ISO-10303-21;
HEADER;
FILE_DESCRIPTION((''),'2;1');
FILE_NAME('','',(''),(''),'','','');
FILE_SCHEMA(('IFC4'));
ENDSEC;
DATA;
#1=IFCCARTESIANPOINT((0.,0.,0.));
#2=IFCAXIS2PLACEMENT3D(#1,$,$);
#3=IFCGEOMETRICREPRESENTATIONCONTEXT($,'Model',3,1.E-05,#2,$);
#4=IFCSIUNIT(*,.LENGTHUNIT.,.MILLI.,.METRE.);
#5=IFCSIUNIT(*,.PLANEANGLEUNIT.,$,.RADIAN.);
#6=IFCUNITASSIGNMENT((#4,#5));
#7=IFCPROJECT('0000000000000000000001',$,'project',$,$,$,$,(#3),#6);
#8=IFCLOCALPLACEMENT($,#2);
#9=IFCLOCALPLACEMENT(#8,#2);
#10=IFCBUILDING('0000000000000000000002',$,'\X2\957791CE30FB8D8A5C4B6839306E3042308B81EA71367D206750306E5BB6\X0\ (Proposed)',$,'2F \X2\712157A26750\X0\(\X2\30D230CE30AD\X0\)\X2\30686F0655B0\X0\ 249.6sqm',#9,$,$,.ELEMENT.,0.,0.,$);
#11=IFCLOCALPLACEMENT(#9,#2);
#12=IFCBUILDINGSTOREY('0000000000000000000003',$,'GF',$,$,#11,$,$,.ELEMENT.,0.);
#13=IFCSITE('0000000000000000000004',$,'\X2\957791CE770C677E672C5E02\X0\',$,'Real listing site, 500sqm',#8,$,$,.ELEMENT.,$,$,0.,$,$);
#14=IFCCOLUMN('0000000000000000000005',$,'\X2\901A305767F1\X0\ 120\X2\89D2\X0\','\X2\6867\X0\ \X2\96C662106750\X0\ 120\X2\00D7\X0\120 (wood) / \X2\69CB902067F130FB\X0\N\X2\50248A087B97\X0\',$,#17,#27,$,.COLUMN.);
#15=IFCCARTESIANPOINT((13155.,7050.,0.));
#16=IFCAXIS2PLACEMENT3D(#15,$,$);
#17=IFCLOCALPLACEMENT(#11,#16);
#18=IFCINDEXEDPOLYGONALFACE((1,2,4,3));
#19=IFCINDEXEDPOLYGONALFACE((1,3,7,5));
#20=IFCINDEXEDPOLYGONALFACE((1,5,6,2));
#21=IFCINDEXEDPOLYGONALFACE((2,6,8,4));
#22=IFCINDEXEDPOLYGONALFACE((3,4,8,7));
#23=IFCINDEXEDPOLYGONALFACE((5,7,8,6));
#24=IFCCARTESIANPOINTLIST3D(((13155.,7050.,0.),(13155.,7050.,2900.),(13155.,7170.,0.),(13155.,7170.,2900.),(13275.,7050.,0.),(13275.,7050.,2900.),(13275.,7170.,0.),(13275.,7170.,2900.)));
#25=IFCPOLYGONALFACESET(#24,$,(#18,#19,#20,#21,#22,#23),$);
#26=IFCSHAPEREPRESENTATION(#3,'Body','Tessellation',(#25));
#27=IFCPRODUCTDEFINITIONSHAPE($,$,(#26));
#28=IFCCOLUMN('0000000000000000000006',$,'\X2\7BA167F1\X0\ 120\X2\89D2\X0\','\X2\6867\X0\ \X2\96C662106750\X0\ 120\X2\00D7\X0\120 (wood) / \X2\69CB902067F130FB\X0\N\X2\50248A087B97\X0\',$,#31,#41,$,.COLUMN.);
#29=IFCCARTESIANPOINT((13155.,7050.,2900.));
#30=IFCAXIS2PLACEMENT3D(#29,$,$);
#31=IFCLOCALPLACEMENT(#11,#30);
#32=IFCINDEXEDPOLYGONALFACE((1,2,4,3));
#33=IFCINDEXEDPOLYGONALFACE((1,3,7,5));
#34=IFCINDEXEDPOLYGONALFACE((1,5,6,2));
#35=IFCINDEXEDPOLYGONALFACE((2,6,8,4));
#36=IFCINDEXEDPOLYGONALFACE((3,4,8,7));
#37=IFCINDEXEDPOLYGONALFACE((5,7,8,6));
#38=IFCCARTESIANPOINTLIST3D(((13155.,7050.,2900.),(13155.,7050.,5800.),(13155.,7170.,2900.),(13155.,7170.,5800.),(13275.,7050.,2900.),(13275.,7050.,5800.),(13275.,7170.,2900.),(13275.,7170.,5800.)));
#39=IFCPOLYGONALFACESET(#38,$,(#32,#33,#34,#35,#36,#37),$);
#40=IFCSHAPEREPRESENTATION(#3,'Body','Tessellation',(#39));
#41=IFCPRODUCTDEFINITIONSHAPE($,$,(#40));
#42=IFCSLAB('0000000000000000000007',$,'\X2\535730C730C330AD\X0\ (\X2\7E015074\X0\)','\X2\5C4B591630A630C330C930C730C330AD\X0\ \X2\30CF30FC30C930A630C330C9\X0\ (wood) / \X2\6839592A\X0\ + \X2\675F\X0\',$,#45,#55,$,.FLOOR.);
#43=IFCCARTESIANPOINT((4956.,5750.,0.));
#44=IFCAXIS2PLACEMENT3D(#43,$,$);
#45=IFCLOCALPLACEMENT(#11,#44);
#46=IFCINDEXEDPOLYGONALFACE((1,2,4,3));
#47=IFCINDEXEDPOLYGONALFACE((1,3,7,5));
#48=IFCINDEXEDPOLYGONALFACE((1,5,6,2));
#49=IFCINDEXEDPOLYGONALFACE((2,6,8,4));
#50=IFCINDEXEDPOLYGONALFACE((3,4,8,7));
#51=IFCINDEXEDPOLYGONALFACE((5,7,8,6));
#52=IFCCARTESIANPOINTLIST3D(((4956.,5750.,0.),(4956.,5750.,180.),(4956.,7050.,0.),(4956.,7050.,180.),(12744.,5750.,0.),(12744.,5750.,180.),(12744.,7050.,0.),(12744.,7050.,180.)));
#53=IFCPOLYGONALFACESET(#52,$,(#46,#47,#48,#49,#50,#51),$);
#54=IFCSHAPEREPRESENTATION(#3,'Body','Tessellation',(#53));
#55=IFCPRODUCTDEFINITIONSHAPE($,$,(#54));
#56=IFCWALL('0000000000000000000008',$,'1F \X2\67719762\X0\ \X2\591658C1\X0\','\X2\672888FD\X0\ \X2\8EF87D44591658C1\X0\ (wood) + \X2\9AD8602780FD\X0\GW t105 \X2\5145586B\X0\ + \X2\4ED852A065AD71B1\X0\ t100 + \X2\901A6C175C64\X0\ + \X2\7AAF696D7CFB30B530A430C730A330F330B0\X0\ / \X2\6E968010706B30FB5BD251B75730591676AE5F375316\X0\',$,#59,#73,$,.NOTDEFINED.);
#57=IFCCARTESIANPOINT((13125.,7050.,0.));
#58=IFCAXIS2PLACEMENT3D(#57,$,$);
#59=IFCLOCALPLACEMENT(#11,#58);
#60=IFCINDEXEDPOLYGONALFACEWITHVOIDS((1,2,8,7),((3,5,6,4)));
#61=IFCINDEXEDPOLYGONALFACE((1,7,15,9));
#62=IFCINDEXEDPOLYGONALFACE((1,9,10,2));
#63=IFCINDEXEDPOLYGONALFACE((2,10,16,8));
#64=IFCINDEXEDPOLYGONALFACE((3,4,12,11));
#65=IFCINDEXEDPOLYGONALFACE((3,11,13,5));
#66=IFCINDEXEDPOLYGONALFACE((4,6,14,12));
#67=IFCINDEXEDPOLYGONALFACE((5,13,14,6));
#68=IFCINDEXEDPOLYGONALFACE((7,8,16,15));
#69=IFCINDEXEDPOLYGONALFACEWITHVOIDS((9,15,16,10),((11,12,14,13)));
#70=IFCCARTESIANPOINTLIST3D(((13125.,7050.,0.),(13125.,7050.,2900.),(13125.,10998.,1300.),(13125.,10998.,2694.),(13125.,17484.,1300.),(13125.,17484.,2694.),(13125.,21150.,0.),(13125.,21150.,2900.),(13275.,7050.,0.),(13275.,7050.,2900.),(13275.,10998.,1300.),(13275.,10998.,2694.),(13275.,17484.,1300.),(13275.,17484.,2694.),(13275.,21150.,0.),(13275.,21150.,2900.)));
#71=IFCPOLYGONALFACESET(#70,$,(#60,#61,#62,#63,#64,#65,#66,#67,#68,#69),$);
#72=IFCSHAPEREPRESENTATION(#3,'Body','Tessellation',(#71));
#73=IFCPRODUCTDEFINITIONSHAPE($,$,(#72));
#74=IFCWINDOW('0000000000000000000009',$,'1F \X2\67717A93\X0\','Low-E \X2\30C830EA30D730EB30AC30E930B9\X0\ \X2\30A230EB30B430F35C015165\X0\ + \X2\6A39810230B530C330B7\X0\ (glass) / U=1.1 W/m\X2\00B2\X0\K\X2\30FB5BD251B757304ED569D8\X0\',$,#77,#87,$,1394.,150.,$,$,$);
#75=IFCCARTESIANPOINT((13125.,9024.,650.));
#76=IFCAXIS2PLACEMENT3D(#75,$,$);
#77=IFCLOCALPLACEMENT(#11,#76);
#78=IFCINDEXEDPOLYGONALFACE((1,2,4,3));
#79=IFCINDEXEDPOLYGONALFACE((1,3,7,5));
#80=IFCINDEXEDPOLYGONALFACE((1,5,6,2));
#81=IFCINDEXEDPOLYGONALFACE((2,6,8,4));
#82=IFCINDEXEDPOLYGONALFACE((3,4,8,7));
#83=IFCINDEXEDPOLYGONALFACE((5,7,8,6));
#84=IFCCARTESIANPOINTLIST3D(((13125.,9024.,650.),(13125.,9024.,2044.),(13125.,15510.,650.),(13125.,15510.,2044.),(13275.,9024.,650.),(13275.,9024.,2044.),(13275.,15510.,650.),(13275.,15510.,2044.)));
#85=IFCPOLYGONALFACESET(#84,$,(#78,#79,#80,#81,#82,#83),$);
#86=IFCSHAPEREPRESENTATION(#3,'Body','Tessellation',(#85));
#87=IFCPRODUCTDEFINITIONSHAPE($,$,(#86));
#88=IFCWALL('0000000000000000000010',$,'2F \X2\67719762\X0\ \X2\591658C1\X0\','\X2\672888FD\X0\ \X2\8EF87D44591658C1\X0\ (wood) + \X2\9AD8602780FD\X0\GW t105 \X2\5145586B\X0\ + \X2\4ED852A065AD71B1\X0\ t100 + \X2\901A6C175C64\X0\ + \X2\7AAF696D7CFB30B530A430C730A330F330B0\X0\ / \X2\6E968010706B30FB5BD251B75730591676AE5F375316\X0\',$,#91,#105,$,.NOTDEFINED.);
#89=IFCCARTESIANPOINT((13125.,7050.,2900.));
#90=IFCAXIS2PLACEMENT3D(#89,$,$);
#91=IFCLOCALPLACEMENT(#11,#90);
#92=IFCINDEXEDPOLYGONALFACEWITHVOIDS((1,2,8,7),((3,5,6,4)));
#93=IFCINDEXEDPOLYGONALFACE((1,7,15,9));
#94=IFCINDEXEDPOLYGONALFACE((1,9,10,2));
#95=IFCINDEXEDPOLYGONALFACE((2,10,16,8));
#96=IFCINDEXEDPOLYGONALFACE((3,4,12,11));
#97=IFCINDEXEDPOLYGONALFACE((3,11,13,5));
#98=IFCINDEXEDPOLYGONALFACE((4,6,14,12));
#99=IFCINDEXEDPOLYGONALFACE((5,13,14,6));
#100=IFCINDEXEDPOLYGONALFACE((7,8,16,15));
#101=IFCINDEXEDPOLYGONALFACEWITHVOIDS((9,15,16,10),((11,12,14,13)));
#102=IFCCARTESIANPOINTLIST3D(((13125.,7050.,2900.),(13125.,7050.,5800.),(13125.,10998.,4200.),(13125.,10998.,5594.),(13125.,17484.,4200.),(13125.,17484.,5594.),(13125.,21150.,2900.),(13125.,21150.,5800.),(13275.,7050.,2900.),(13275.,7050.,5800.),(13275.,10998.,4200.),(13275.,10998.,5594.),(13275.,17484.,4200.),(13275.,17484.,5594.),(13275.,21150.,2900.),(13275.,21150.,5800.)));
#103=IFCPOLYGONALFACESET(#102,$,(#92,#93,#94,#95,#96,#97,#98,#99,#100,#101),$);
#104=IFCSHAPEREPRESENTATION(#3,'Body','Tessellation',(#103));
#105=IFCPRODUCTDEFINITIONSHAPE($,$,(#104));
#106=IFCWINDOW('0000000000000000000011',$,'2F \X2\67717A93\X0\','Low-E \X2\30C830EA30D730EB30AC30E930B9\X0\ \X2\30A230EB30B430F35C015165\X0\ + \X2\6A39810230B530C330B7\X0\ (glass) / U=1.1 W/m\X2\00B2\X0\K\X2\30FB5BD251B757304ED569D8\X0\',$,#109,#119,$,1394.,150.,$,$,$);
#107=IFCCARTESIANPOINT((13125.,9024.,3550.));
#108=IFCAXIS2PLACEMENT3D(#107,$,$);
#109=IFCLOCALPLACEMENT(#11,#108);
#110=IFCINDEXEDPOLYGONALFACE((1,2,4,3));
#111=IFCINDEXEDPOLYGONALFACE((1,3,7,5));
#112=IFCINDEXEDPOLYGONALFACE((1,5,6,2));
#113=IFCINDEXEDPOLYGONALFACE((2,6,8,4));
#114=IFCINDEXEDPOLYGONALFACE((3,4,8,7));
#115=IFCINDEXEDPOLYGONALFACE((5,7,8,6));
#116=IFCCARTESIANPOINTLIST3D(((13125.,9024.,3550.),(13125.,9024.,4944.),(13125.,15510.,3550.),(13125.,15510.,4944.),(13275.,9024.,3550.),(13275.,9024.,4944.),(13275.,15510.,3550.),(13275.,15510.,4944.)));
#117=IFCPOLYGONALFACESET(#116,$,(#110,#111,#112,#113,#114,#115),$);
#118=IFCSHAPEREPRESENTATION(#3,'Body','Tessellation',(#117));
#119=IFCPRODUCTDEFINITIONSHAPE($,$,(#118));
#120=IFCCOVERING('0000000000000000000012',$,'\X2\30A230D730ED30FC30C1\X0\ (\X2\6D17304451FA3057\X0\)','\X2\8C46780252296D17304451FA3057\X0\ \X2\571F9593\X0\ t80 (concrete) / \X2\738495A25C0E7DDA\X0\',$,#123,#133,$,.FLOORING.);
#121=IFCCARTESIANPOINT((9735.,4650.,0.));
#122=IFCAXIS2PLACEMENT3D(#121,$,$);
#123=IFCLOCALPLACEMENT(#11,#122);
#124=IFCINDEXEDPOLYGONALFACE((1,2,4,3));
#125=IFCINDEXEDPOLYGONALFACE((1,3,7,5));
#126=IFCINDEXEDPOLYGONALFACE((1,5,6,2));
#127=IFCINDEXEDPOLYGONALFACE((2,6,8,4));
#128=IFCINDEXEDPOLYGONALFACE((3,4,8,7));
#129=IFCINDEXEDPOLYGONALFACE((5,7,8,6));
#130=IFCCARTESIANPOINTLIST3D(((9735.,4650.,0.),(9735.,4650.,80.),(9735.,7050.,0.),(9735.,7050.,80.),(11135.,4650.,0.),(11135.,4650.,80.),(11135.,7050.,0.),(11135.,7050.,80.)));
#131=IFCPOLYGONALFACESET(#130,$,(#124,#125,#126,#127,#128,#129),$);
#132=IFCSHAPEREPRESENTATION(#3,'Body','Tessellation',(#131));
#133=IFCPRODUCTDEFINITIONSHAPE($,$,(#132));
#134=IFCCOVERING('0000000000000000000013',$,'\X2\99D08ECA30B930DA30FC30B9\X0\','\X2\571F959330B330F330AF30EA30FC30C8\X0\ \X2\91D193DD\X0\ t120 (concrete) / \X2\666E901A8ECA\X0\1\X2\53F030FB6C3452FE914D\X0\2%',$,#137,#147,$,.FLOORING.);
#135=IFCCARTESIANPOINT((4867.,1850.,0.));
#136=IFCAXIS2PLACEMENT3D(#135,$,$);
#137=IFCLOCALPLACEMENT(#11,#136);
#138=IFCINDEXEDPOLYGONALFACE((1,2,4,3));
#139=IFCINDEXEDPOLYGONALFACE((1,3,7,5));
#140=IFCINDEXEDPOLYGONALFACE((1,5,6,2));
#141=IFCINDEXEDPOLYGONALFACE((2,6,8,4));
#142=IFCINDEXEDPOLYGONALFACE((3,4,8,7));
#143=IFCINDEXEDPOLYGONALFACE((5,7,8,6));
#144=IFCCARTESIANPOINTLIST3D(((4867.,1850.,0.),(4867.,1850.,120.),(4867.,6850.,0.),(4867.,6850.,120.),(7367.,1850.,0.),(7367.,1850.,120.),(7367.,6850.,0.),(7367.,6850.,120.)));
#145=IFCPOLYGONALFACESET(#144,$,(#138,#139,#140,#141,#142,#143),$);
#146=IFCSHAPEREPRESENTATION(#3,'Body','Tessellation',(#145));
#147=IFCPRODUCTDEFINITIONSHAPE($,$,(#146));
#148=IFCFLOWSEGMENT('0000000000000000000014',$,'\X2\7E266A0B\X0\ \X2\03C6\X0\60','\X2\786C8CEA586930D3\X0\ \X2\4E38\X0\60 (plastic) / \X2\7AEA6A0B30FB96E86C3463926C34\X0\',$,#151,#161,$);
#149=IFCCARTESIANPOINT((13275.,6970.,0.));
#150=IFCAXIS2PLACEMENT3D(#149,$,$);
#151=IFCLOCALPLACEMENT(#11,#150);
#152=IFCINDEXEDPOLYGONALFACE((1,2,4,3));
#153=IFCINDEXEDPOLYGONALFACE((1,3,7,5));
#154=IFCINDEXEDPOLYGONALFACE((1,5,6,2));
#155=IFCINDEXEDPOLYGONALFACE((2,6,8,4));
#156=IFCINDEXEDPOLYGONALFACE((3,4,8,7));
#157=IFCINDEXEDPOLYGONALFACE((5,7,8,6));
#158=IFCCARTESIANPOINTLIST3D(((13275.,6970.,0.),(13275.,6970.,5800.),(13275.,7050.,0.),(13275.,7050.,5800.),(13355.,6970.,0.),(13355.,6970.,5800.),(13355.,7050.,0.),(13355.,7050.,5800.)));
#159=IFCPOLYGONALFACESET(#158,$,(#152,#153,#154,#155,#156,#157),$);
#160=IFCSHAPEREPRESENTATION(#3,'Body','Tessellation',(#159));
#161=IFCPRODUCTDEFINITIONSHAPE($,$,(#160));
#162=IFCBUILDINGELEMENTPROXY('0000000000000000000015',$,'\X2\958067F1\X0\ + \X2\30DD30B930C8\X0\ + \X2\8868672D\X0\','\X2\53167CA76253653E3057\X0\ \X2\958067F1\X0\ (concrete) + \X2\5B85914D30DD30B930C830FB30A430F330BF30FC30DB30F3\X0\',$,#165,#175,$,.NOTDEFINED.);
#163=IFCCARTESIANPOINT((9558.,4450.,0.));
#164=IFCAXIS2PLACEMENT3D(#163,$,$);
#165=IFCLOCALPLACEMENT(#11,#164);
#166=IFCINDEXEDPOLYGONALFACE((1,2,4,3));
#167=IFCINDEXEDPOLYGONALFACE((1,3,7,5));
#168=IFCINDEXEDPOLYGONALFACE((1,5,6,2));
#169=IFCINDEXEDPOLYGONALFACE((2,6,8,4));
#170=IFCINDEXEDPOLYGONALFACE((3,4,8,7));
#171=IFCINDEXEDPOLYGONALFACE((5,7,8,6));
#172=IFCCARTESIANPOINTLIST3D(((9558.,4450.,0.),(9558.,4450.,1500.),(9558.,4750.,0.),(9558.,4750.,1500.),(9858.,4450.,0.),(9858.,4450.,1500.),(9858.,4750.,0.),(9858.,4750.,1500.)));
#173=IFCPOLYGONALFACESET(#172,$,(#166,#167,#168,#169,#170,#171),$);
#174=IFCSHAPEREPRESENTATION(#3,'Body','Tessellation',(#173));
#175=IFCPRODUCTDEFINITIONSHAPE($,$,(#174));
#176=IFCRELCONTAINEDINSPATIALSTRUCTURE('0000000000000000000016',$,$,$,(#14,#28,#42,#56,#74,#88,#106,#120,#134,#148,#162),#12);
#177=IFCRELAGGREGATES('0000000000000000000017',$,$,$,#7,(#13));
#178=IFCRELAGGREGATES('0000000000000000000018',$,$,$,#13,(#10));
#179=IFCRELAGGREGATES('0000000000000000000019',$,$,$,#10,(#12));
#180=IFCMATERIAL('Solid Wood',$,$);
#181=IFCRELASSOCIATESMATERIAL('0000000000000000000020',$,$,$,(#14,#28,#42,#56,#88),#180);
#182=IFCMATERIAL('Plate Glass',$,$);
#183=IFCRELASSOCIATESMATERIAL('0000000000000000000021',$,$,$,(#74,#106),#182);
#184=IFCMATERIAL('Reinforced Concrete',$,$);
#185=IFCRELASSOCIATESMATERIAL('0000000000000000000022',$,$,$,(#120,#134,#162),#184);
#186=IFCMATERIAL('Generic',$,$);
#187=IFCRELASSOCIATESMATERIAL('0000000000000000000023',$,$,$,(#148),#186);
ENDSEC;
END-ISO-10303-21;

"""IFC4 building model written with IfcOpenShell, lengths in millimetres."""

from ifc_helpers import new_model, si_unit, frame, frame_2d, origin, place, context, project, spatial, rectangle, extrude, material, element, fill, save


model = new_model("IFC4")

# Units and contexts
model_context = context("Model", 3, precision=1e-05, world=origin())
ifc_project = project(units=[si_unit("LENGTHUNIT", "METRE", prefix="MILLI"), si_unit("PLANEANGLEUNIT", "RADIAN")], contexts=[model_context])

# Site, building, storey
site_placement = place(None, origin())
site = spatial("IfcSite", under=ifc_project, at=site_placement, Name="長野県松本市", ObjectType="Real listing site, 500sqm", CompositionType="ELEMENT", RefElevation=0.0)
building_placement = place(site_placement, origin())
building = spatial("IfcBuilding", under=site, at=building_placement, Name="長野・越屋根のある自然素材の家 (Proposed)", ObjectType="2F 無垢材(ヒノキ)と漆喰 249.6sqm", CompositionType="ELEMENT", ElevationOfRefHeight=0.0, ElevationOfTerrain=0.0)
storey_placement = place(building_placement, origin())
storey = spatial("IfcBuildingStorey", under=building, at=storey_placement, Name="GF", CompositionType="ELEMENT", Elevation=0.0)

# Columns
ifc_material_1 = material(Name="Solid Wood")
column_1_placement = place(storey_placement, frame((13155.0, 7050.0, 0.0)))
element("IfcColumn", 1, at=column_1_placement, inside=storey, material=ifc_material_1, Name="通し柱 120角", Description="桧 集成材 120×120 (wood) / 構造柱・N値計算", PredefinedType="COLUMN", context=model_context, shape_type="SweptSolid", body=[
    extrude(rectangle(XDim=120.0, YDim=120.0, at=frame_2d((60.0, 60.0))), frame((13155.0, 7050.0, 0.0)), (0.0, 0.0, 1.0), 2900.0),
])
column_2_placement = place(storey_placement, frame((13155.0, 7050.0, 2900.0)))
element("IfcColumn", 2, at=column_2_placement, inside=storey, material=ifc_material_1, Name="管柱 120角", Description="桧 集成材 120×120 (wood) / 構造柱・N値計算", PredefinedType="COLUMN", context=model_context, shape_type="SweptSolid", body=[
    extrude(rectangle(XDim=120.0, YDim=120.0, at=frame_2d((60.0, 60.0))), frame((13155.0, 7050.0, 2900.0)), (0.0, 0.0, 1.0), 2900.0),
])

# Slab
slab_placement = place(storey_placement, frame((4956.0, 5750.0, 0.0)))
element("IfcSlab", 3, at=slab_placement, inside=storey, material=ifc_material_1, Name="南デッキ (縁側)", Description="屋外ウッドデッキ ハードウッド (wood) / 根太 + 束", PredefinedType="FLOOR", context=model_context, shape_type="SweptSolid", body=[
    extrude(rectangle(XDim=7788.0, YDim=1300.0, at=frame_2d((3894.0, 650.0))), frame((4956.0, 5750.0, 0.0)), (0.0, 0.0, 1.0), 180.0),
])

# Walls, openings, windows
wall_1_placement = place(storey_placement, frame((13125.0, 7050.0, 0.0)))
wall_1 = element("IfcWall", 4, at=wall_1_placement, inside=storey, material=ifc_material_1, Name="1F 東面 外壁", Description="木製 軸組外壁 (wood) + 高性能GW t105 充填 + 付加断熱 t100 + 通気層 + 窯業系サイディング / 準耐火・寒冷地外皮強化", PredefinedType="NOTDEFINED", context=model_context, shape_type="SweptSolid", body=[
    extrude(rectangle(XDim=150.0, YDim=14100.0, at=frame_2d((75.0, 7050.0))), frame((13125.0, 7050.0, 0.0)), (0.0, 0.0, 1.0), 2900.0),
])
opening_1_placement = place(storey_placement, frame((13125.0, 9024.0, 650.0)))
opening_1 = element("IfcOpeningElement", 5, at=opening_1_placement, cuts=wall_1, PredefinedType="NOTDEFINED", context=model_context, shape_type="SweptSolid", body=[
    extrude(rectangle(XDim=150.0, YDim=6486.0, at=frame_2d((75.0, 3243.0))), frame((13125.0, 9024.0, 650.0)), (0.0, 0.0, 1.0), 1394.0),
])
ifc_material_2 = material(Name="Plate Glass")
window_1_placement = place(storey_placement, frame((13125.0, 9024.0, 650.0)))
window_1 = element("IfcWindow", 6, at=window_1_placement, inside=storey, material=ifc_material_2, Name="1F 東窓", Description="Low-E トリプルガラス アルゴン封入 + 樹脂サッシ (glass) / U=1.1 W/m²K・寒冷地仕様", OverallHeight=1394.0, OverallWidth=150.0, context=model_context, shape_type="SweptSolid", body=[
    extrude(rectangle(XDim=150.0, YDim=6486.0, at=frame_2d((75.0, 3243.0))), frame((13125.0, 9024.0, 650.0)), (0.0, 0.0, 1.0), 1394.0),
])
fill(opening_1, window_1)
wall_2_placement = place(storey_placement, frame((13125.0, 7050.0, 2900.0)))
wall_2 = element("IfcWall", 7, at=wall_2_placement, inside=storey, material=ifc_material_1, Name="2F 東面 外壁", Description="木製 軸組外壁 (wood) + 高性能GW t105 充填 + 付加断熱 t100 + 通気層 + 窯業系サイディング / 準耐火・寒冷地外皮強化", PredefinedType="NOTDEFINED", context=model_context, shape_type="SweptSolid", body=[
    extrude(rectangle(XDim=150.0, YDim=14100.0, at=frame_2d((75.0, 7050.0))), frame((13125.0, 7050.0, 2900.0)), (0.0, 0.0, 1.0), 2900.0),
])
opening_2_placement = place(storey_placement, frame((13125.0, 9024.0, 3550.0)))
opening_2 = element("IfcOpeningElement", 8, at=opening_2_placement, cuts=wall_2, PredefinedType="NOTDEFINED", context=model_context, shape_type="SweptSolid", body=[
    extrude(rectangle(XDim=150.0, YDim=6486.0, at=frame_2d((75.0, 3243.0))), frame((13125.0, 9024.0, 3550.0)), (0.0, 0.0, 1.0), 1394.0),
])
window_2_placement = place(storey_placement, frame((13125.0, 9024.0, 3550.0)))
window_2 = element("IfcWindow", 9, at=window_2_placement, inside=storey, material=ifc_material_2, Name="2F 東窓", Description="Low-E トリプルガラス アルゴン封入 + 樹脂サッシ (glass) / U=1.1 W/m²K・寒冷地仕様", OverallHeight=1394.0, OverallWidth=150.0, context=model_context, shape_type="SweptSolid", body=[
    extrude(rectangle(XDim=150.0, YDim=6486.0, at=frame_2d((75.0, 3243.0))), frame((13125.0, 9024.0, 3550.0)), (0.0, 0.0, 1.0), 1394.0),
])
fill(opening_2, window_2)

# Coverings
ifc_material_3 = material(Name="Reinforced Concrete")
covering_1_placement = place(storey_placement, frame((9735.0, 4650.0, 0.0)))
element("IfcCovering", 10, at=covering_1_placement, inside=storey, material=ifc_material_3, Name="アプローチ (洗い出し)", Description="豆砂利洗い出し 土間 t80 (concrete) / 玄関導線", PredefinedType="FLOORING", context=model_context, shape_type="SweptSolid", body=[
    extrude(rectangle(XDim=1400.0, YDim=2400.0, at=frame_2d((700.0, 1200.0))), frame((9735.0, 4650.0, 0.0)), (0.0, 0.0, 1.0), 80.0),
])
covering_2_placement = place(storey_placement, frame((4867.0, 1850.0, 0.0)))
element("IfcCovering", 11, at=covering_2_placement, inside=storey, material=ifc_material_3, Name="駐車スペース", Description="土間コンクリート 金鏝 t120 (concrete) / 普通車1台・水勾配2%", PredefinedType="FLOORING", context=model_context, shape_type="SweptSolid", body=[
    extrude(rectangle(XDim=2500.0, YDim=5000.0, at=frame_2d((1250.0, 2500.0))), frame((4867.0, 1850.0, 0.0)), (0.0, 0.0, 1.0), 120.0),
])

# Flow segment
ifc_material_4 = material(Name="Generic")
flow_segment_placement = place(storey_placement, frame((13275.0, 6970.0, 0.0)))
element("IfcFlowSegment", 12, at=flow_segment_placement, inside=storey, material=ifc_material_4, Name="縦樋 φ60", Description="硬質塩ビ 丸60 (plastic) / 竪樋・雨水排水", context=model_context, shape_type="SweptSolid", body=[
    extrude(rectangle(XDim=80.0, YDim=80.0, at=frame_2d((40.0, 40.0))), frame((13275.0, 6970.0, 0.0)), (0.0, 0.0, 1.0), 5800.0),
])

# Building element proxy
proxy_placement = place(storey_placement, frame((9558.0, 4450.0, 0.0)))
element("IfcBuildingElementProxy", 13, at=proxy_placement, inside=storey, material=ifc_material_3, Name="門柱 + ポスト + 表札", Description="化粧打放し 門柱 (concrete) + 宅配ポスト・インターホン", PredefinedType="NOTDEFINED", context=model_context, shape_type="SweptSolid", body=[
    extrude(rectangle(XDim=300.0, YDim=300.0, at=frame_2d((150.0, 150.0))), frame((9558.0, 4450.0, 0.0)), (0.0, 0.0, 1.0), 1500.0),
])

save(model, "model.ifc")
